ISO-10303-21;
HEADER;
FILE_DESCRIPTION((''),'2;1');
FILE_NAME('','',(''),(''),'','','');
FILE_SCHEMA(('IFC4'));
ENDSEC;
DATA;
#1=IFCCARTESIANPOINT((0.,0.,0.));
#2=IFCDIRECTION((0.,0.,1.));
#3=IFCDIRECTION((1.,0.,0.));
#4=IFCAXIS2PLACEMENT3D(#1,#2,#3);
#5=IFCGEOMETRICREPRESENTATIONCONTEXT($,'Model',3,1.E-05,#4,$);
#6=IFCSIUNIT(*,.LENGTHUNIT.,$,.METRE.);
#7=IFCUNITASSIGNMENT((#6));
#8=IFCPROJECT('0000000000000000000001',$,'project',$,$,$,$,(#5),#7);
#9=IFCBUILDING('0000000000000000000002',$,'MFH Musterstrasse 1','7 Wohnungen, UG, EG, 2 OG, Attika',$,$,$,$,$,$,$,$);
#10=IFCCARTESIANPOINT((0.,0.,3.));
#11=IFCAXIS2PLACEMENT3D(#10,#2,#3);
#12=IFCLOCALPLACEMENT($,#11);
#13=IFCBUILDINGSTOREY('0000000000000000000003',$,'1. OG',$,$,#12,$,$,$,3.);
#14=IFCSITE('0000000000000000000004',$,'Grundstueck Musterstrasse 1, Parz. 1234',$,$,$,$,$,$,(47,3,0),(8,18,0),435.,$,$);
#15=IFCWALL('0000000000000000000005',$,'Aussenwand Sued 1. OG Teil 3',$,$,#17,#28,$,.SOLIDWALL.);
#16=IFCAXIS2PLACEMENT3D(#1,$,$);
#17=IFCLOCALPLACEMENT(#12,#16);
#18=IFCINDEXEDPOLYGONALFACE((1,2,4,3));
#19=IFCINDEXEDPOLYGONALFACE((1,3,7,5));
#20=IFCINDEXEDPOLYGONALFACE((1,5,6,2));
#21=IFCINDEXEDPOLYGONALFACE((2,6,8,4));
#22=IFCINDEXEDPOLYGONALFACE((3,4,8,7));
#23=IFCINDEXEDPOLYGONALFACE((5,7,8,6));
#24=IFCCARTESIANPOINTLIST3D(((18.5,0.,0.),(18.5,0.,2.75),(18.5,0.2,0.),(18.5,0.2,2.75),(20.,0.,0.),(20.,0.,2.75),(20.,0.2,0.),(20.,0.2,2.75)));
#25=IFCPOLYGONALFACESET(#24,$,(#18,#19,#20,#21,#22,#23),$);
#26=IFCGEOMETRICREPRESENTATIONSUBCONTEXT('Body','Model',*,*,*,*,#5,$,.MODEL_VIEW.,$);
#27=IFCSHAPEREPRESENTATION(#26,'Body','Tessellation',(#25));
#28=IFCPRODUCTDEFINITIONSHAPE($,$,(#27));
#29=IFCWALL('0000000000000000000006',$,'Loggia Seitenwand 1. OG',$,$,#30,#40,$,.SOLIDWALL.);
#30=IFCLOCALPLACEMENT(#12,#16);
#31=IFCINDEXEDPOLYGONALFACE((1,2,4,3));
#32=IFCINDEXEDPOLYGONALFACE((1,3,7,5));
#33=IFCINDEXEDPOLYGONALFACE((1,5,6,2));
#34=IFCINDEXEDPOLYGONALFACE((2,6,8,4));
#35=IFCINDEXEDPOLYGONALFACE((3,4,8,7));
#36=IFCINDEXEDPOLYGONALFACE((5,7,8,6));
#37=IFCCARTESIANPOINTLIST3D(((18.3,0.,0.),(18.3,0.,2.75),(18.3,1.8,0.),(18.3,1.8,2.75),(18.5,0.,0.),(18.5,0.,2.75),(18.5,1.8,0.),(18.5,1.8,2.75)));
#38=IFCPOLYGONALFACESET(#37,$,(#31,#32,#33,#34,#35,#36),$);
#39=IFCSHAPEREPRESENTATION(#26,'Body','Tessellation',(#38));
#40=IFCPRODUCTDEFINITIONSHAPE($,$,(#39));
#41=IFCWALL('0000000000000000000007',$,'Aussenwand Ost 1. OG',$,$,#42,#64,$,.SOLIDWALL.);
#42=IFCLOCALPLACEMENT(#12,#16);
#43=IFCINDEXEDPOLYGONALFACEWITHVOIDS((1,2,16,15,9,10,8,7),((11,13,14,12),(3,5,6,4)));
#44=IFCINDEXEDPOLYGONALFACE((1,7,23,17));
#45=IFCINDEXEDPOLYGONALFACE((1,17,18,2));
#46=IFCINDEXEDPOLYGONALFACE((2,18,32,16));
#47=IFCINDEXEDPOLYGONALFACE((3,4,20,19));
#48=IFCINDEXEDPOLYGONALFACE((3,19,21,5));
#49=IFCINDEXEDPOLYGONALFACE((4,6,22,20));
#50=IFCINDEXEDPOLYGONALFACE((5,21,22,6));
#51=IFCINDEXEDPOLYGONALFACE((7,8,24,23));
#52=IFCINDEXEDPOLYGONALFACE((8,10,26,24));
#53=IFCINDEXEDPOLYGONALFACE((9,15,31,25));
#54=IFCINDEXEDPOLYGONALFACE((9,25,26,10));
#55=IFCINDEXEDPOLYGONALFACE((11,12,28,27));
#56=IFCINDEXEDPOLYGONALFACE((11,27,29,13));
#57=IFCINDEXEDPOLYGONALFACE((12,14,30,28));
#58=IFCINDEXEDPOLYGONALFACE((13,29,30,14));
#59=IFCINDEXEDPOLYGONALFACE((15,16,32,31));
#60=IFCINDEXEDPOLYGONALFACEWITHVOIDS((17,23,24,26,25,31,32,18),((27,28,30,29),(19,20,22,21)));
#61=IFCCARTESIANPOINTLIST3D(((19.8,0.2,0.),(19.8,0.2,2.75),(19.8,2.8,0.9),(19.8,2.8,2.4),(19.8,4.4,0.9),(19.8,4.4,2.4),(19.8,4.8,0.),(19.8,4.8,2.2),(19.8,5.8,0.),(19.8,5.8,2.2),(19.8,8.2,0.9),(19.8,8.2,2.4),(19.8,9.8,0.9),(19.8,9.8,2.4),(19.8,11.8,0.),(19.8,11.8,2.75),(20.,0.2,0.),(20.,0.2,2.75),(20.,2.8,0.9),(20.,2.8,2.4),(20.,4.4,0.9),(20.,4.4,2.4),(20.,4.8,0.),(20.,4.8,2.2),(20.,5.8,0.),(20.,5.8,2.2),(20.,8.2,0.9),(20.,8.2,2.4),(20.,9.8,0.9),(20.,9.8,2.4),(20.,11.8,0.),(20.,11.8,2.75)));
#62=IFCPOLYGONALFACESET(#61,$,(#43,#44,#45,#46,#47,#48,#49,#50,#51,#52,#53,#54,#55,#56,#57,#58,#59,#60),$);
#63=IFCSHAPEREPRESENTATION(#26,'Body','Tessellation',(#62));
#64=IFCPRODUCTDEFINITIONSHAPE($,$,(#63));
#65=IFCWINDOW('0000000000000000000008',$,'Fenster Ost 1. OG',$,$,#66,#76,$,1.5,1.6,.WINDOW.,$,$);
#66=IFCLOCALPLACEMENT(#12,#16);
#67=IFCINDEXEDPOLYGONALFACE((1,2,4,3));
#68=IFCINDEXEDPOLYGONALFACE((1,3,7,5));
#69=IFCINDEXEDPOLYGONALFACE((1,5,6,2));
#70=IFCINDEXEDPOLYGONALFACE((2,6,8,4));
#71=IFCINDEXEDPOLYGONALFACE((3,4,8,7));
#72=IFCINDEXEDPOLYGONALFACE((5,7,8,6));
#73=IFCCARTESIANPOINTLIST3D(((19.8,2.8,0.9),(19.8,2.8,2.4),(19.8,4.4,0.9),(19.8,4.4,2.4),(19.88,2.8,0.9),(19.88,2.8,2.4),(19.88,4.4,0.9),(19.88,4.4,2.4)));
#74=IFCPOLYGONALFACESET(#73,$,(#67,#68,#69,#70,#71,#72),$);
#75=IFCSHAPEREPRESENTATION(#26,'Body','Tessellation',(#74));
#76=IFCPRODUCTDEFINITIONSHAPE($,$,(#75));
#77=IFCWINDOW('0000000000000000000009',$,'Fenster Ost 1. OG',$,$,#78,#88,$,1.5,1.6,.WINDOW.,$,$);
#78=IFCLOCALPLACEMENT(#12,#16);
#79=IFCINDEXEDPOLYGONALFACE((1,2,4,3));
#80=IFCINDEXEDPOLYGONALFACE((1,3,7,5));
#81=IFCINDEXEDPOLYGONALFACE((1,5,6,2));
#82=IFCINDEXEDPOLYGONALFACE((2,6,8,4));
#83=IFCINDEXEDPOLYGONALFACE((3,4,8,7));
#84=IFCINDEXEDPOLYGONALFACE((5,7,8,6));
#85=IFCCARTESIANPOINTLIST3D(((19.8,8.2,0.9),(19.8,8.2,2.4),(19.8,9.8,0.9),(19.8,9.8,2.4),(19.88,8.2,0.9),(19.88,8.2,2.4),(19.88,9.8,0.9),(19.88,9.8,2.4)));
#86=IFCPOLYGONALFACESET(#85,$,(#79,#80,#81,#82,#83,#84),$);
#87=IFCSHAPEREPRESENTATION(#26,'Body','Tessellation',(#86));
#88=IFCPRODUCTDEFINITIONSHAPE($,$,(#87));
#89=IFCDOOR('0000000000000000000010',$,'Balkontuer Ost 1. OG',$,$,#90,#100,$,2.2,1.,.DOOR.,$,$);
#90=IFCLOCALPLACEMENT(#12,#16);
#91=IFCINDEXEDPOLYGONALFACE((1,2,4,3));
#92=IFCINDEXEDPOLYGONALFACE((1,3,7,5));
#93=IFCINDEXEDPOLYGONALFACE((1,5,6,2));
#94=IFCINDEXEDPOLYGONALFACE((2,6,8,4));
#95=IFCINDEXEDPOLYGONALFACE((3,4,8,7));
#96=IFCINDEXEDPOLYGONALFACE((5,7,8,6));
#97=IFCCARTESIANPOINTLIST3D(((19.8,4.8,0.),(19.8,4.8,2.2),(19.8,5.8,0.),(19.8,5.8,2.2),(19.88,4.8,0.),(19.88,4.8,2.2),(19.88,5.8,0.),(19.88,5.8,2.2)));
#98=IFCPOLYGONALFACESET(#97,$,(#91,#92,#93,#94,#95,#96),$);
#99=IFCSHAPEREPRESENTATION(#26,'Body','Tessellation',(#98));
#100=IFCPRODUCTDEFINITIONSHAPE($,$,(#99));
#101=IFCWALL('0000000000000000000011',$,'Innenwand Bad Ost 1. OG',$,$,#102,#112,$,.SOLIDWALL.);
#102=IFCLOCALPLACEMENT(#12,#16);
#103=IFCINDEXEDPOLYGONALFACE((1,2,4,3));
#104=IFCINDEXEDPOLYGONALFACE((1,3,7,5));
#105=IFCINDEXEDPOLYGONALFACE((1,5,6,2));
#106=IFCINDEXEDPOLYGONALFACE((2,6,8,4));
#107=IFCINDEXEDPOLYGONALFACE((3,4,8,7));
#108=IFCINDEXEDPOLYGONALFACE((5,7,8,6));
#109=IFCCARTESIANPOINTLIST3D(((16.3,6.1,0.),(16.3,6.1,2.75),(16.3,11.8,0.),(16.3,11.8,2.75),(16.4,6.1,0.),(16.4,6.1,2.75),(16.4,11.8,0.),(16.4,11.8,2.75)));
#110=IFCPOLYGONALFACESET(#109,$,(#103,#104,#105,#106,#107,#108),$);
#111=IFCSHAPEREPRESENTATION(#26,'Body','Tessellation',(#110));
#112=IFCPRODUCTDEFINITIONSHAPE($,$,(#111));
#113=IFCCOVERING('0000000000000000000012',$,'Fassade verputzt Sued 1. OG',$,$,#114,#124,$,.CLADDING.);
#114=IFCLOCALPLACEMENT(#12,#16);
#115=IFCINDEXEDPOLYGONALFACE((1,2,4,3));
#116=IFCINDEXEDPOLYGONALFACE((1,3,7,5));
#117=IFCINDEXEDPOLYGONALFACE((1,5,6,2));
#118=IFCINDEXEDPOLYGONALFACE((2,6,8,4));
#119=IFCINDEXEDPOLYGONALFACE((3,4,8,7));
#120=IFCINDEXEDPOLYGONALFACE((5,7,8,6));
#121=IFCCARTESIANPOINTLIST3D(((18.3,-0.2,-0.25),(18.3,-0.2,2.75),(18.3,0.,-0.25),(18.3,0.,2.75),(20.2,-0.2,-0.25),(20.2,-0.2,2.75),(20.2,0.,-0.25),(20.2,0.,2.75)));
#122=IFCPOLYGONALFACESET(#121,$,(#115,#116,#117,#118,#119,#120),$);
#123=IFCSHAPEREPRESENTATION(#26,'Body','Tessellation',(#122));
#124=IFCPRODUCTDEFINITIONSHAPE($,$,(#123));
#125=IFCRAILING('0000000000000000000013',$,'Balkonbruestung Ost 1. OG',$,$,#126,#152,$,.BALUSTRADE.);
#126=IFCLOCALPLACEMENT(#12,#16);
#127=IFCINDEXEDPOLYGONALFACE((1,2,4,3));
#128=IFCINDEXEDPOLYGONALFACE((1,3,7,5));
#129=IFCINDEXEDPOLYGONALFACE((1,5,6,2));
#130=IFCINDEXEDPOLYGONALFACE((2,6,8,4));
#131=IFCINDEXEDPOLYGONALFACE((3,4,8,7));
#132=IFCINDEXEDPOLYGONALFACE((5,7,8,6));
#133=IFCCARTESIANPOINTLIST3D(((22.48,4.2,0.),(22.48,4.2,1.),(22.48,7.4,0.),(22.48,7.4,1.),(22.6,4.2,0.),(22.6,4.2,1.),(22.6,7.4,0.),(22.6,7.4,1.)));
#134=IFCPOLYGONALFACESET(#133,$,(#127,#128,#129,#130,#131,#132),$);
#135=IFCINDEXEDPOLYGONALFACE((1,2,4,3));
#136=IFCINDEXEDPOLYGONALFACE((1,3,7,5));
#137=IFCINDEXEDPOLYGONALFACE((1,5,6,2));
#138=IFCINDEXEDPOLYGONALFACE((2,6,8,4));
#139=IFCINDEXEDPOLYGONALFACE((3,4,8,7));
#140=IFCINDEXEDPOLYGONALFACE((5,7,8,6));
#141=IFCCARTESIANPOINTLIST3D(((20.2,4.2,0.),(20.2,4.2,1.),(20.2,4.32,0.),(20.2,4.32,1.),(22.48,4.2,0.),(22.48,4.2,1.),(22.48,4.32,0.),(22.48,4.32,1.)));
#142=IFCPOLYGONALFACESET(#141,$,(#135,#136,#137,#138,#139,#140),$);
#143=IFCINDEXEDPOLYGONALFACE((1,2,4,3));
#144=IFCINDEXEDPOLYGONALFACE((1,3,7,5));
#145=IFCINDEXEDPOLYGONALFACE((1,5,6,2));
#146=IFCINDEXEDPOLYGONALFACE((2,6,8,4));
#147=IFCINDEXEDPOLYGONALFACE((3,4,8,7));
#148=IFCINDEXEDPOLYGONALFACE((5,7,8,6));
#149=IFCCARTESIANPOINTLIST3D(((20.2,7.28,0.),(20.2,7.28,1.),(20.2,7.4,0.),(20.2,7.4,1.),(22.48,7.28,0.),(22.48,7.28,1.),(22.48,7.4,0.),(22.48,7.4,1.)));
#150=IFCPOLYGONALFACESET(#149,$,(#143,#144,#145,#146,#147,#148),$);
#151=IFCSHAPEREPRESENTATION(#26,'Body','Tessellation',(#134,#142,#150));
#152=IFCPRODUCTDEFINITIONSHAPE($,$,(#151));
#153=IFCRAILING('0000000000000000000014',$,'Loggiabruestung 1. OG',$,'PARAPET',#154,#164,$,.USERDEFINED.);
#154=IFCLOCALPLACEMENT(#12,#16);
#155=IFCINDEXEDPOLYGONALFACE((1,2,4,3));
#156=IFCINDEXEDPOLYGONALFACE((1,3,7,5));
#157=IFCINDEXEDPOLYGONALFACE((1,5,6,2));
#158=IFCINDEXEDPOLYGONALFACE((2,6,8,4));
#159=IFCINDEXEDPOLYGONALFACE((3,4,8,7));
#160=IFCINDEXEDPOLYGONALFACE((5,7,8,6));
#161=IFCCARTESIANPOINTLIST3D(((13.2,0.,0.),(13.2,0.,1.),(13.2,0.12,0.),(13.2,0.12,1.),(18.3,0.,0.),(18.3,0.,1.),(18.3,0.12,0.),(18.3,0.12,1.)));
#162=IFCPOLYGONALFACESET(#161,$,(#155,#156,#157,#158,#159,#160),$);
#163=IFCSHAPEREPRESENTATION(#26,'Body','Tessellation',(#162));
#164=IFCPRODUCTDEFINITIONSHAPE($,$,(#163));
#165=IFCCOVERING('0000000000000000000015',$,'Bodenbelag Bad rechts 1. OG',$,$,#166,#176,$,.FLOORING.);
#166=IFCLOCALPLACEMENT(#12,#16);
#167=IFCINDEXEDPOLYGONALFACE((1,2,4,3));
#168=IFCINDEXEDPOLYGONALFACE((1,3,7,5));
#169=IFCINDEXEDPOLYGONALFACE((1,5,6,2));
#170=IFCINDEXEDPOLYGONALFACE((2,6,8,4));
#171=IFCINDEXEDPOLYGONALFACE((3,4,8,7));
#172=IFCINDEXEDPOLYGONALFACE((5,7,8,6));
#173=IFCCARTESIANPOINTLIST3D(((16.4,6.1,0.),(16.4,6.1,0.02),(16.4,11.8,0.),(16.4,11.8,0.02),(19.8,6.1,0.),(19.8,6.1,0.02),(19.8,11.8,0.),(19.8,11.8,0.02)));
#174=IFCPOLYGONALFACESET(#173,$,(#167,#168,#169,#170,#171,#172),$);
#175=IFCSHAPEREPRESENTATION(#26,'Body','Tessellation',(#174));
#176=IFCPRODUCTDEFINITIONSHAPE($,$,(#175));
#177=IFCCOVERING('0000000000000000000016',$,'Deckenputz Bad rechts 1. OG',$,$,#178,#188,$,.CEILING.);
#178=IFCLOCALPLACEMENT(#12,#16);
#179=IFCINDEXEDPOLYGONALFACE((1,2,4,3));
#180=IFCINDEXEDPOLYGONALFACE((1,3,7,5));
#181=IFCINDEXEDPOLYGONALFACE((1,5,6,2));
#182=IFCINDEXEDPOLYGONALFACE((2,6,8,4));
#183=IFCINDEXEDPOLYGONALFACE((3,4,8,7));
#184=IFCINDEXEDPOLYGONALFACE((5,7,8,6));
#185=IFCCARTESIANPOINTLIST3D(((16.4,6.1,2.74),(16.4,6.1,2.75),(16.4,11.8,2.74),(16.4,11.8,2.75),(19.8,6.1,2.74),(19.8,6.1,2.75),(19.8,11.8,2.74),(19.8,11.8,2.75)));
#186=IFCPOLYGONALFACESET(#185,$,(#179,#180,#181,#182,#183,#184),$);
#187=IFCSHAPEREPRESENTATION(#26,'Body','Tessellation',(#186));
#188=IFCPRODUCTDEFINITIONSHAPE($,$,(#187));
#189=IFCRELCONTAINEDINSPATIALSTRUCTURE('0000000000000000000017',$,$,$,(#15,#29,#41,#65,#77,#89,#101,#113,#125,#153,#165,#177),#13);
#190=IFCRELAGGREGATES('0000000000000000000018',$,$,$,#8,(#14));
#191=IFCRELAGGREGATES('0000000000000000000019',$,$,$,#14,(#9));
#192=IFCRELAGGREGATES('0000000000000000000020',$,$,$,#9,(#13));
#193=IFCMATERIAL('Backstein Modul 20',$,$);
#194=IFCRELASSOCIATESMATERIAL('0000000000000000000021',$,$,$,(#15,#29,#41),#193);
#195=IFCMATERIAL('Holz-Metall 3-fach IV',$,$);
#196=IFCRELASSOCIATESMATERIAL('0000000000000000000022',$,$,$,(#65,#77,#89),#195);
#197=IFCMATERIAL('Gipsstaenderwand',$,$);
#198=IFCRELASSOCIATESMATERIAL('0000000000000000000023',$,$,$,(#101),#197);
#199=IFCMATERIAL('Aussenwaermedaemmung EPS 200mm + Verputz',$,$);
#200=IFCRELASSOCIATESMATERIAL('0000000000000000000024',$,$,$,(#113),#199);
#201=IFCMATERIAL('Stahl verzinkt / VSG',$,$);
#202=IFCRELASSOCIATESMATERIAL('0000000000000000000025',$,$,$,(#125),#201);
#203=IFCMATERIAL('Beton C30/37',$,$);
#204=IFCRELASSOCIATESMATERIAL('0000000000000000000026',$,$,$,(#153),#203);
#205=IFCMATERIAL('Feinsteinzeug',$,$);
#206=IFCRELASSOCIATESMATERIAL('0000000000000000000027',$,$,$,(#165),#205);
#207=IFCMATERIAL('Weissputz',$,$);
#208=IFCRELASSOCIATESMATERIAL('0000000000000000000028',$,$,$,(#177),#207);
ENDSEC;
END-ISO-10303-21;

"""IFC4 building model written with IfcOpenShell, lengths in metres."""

from ifc_helpers import new_model, si_unit, frame, frame_2d, origin_with_axes, place, context, subcontext, project, spatial, rectangle, extrude, material, element, fill, save


model = new_model("IFC4")

# Units and contexts
model_context = context("Model", 3, precision=1e-05, world=origin_with_axes())
body_context = subcontext(model_context, "Body", "Model", "MODEL_VIEW")
ifc_project = project(units=[si_unit("LENGTHUNIT", "METRE")], contexts=[model_context])

# Site, building, storey
site = spatial("IfcSite", under=ifc_project, Name="Grundstueck Musterstrasse 1, Parz. 1234", RefLatitude=(47, 3, 0), RefLongitude=(8, 18, 0), RefElevation=435.0)
building = spatial("IfcBuilding", under=site, Name="MFH Musterstrasse 1", Description="7 Wohnungen, UG, EG, 2 OG, Attika")
storey_placement = place(None, frame((0.0, 0.0, 3.0), z_axis=(0.0, 0.0, 1.0), x_axis=(1.0, 0.0, 0.0)))
storey = spatial("IfcBuildingStorey", under=building, at=storey_placement, Name="1. OG", Elevation=3.0)

# Walls
ifc_material_1 = material(Name="Backstein Modul 20")
wall_1_placement = place(storey_placement, frame((18.5, 0.0, 0.0), z_axis=(0.0, 0.0, 1.0), x_axis=(1.0, 0.0, 0.0)))
element("IfcWall", 1, at=wall_1_placement, inside=storey, material=ifc_material_1, Name="Aussenwand Sued 1. OG Teil 3", PredefinedType="SOLIDWALL", context=body_context, shape_type="SweptSolid", body=[
    extrude(rectangle(XDim=1.5, YDim=0.2, at=frame_2d((0.75, 0.1))), origin_with_axes(), (0.0, 0.0, 1.0), 2.75),
])
wall_2_placement = place(storey_placement, frame((18.3, 0.2, 0.0), z_axis=(0.0, 0.0, 1.0), x_axis=(1.0, 0.0, 0.0)))
element("IfcWall", 2, at=wall_2_placement, inside=storey, material=ifc_material_1, Name="Loggia Seitenwand 1. OG", PredefinedType="SOLIDWALL", context=body_context, shape_type="SweptSolid", body=[
    extrude(rectangle(XDim=0.2, YDim=1.8, at=frame_2d((0.1, 0.7))), origin_with_axes(), (0.0, 0.0, 1.0), 2.75),
])

# Wall, openings, windows, door
wall_3_placement = place(storey_placement, frame((19.8, 0.2, 0.0), z_axis=(0.0, 0.0, 1.0), x_axis=(1.0, 0.0, 0.0)))
wall_3 = element("IfcWall", 3, at=wall_3_placement, inside=storey, material=ifc_material_1, Name="Aussenwand Ost 1. OG", PredefinedType="SOLIDWALL", context=body_context, shape_type="SweptSolid", body=[
    extrude(rectangle(XDim=0.2, YDim=11.6, at=frame_2d((0.1, 5.8))), origin_with_axes(), (0.0, 0.0, 1.0), 2.75),
])
opening_1_placement = place(wall_3_placement, frame((-0.01, 2.6, 0.9), z_axis=(0.0, 0.0, 1.0), x_axis=(1.0, 0.0, 0.0)))
opening_1 = element("IfcOpeningElement", 4, at=opening_1_placement, cuts=wall_3, context=body_context, shape_type="SweptSolid", body=[
    extrude(rectangle(XDim=0.42, YDim=1.6, at=frame_2d((0.21, 0.8))), origin_with_axes(), (0.0, 0.0, 1.0), 1.5),
])
opening_2_placement = place(wall_3_placement, frame((-0.01, 8.0, 0.9), z_axis=(0.0, 0.0, 1.0), x_axis=(1.0, 0.0, 0.0)))
opening_2 = element("IfcOpeningElement", 5, at=opening_2_placement, cuts=wall_3, context=body_context, shape_type="SweptSolid", body=[
    extrude(rectangle(XDim=0.42, YDim=1.6, at=frame_2d((0.21, 0.8))), origin_with_axes(), (0.0, 0.0, 1.0), 1.5),
])
opening_3_placement = place(wall_3_placement, frame((-0.01, 4.6, 0.0), z_axis=(0.0, 0.0, 1.0), x_axis=(1.0, 0.0, 0.0)))
opening_3 = element("IfcOpeningElement", 6, at=opening_3_placement, cuts=wall_3, context=body_context, shape_type="SweptSolid", body=[
    extrude(rectangle(XDim=0.42, YDim=1.0, at=frame_2d((0.21, 0.5))), origin_with_axes(), (0.0, 0.0, 1.0), 2.2),
])
ifc_material_2 = material(Name="Holz-Metall 3-fach IV")
window_1_placement = place(storey_placement, frame((19.8, 2.8, 0.9), z_axis=(0.0, 0.0, 1.0), x_axis=(1.0, 0.0, 0.0)))
window_1 = element("IfcWindow", 7, at=window_1_placement, inside=storey, material=ifc_material_2, Name="Fenster Ost 1. OG", OverallHeight=1.5, OverallWidth=1.6, PredefinedType="WINDOW", context=body_context, shape_type="SweptSolid", body=[
    extrude(rectangle(XDim=0.08, YDim=1.6, at=frame_2d((0.04, 0.8))), origin_with_axes(), (0.0, 0.0, 1.0), 1.5),
])
fill(opening_1, window_1)
window_2_placement = place(storey_placement, frame((19.8, 8.2, 0.9), z_axis=(0.0, 0.0, 1.0), x_axis=(1.0, 0.0, 0.0)))
window_2 = element("IfcWindow", 8, at=window_2_placement, inside=storey, material=ifc_material_2, Name="Fenster Ost 1. OG", OverallHeight=1.5, OverallWidth=1.6, PredefinedType="WINDOW", context=body_context, shape_type="SweptSolid", body=[
    extrude(rectangle(XDim=0.08, YDim=1.6, at=frame_2d((0.04, 0.8))), origin_with_axes(), (0.0, 0.0, 1.0), 1.5),
])
fill(opening_2, window_2)
door_placement = place(storey_placement, frame((19.8, 4.8, 0.0), z_axis=(0.0, 0.0, 1.0), x_axis=(1.0, 0.0, 0.0)))
door = element("IfcDoor", 9, at=door_placement, inside=storey, material=ifc_material_2, Name="Balkontuer Ost 1. OG", OverallHeight=2.2, OverallWidth=1.0, PredefinedType="DOOR", context=body_context, shape_type="SweptSolid", body=[
    extrude(rectangle(XDim=0.08, YDim=1.0, at=frame_2d((0.04, 0.5))), origin_with_axes(), (0.0, 0.0, 1.0), 2.2),
])
fill(opening_3, door)

# Wall
ifc_material_3 = material(Name="Gipsstaenderwand")
wall_4_placement = place(storey_placement, frame((16.3, 6.1, 0.0), z_axis=(0.0, 0.0, 1.0), x_axis=(1.0, 0.0, 0.0)))
element("IfcWall", 10, at=wall_4_placement, inside=storey, material=ifc_material_3, Name="Innenwand Bad Ost 1. OG", PredefinedType="SOLIDWALL", context=body_context, shape_type="SweptSolid", body=[
    extrude(rectangle(XDim=0.1, YDim=5.7, at=frame_2d((0.05, 2.85))), origin_with_axes(), (0.0, 0.0, 1.0), 2.75),
])

# Shared definitions
ifc_material_4 = material(Name="Aussenwaermedaemmung EPS 200mm + Verputz")

# Covering
covering_1_placement = place(storey_placement, frame((18.5, -0.2, -0.25), z_axis=(0.0, 0.0, 1.0), x_axis=(1.0, 0.0, 0.0)))
element("IfcCovering", 11, at=covering_1_placement, inside=storey, material=ifc_material_4, Name="Fassade verputzt Sued 1. OG", PredefinedType="CLADDING", context=body_context, shape_type="SweptSolid", body=[
    extrude(rectangle(XDim=1.9, YDim=0.2, at=frame_2d((0.75, 0.1))), origin_with_axes(), (0.0, 0.0, 1.0), 3.0),
])

# Railings
ifc_material_5 = material(Name="Stahl verzinkt / VSG")
railing_1_placement = place(storey_placement, frame((22.48, 4.2, 0.0), z_axis=(0.0, 0.0, 1.0), x_axis=(1.0, 0.0, 0.0)))
element("IfcRailing", 12, at=railing_1_placement, inside=storey, material=ifc_material_5, Name="Balkonbruestung Ost 1. OG", PredefinedType="BALUSTRADE", context=body_context, shape_type="SweptSolid", body=[
    extrude(rectangle(XDim=0.12, YDim=3.2, at=frame_2d((0.06, 1.6))), origin_with_axes(), (0.0, 0.0, 1.0), 1.0),
    extrude(rectangle(XDim=2.28, YDim=0.12, at=frame_2d((-1.14, 0.06))), origin_with_axes(), (0.0, 0.0, 1.0), 1.0),
    extrude(rectangle(XDim=2.28, YDim=0.12, at=frame_2d((-1.14, 3.14))), origin_with_axes(), (0.0, 0.0, 1.0), 1.0),
])
ifc_material_6 = material(Name="Beton C30/37")
railing_2_placement = place(storey_placement, frame((13.2, 0.0, 0.0), z_axis=(0.0, 0.0, 1.0), x_axis=(1.0, 0.0, 0.0)))
element("IfcRailing", 13, at=railing_2_placement, inside=storey, material=ifc_material_6, Name="Loggiabruestung 1. OG", ObjectType="PARAPET", PredefinedType="USERDEFINED", context=body_context, shape_type="SweptSolid", body=[
    extrude(rectangle(XDim=5.1, YDim=0.12, at=frame_2d((2.55, 0.06))), origin_with_axes(), (0.0, 0.0, 1.0), 1.0),
])

# Coverings
ifc_material_7 = material(Name="Feinsteinzeug")
covering_2_placement = place(storey_placement, frame((16.4, 6.1, 0.0), z_axis=(0.0, 0.0, 1.0), x_axis=(1.0, 0.0, 0.0)))
element("IfcCovering", 14, at=covering_2_placement, inside=storey, material=ifc_material_7, Name="Bodenbelag Bad rechts 1. OG", PredefinedType="FLOORING", context=body_context, shape_type="SweptSolid", body=[
    extrude(rectangle(XDim=3.4, YDim=5.7, at=frame_2d((1.7, 2.85))), origin_with_axes(), (0.0, 0.0, 1.0), 0.02),
])
ifc_material_8 = material(Name="Weissputz")
covering_3_placement = place(storey_placement, frame((16.4, 6.1, 2.74), z_axis=(0.0, 0.0, 1.0), x_axis=(1.0, 0.0, 0.0)))
element("IfcCovering", 15, at=covering_3_placement, inside=storey, material=ifc_material_8, Name="Deckenputz Bad rechts 1. OG", PredefinedType="CEILING", context=body_context, shape_type="SweptSolid", body=[
    extrude(rectangle(XDim=3.4, YDim=5.7, at=frame_2d((1.7, 2.85))), origin_with_axes(), (0.0, 0.0, 1.0), 0.01),
])

save(model, "model.ifc")
